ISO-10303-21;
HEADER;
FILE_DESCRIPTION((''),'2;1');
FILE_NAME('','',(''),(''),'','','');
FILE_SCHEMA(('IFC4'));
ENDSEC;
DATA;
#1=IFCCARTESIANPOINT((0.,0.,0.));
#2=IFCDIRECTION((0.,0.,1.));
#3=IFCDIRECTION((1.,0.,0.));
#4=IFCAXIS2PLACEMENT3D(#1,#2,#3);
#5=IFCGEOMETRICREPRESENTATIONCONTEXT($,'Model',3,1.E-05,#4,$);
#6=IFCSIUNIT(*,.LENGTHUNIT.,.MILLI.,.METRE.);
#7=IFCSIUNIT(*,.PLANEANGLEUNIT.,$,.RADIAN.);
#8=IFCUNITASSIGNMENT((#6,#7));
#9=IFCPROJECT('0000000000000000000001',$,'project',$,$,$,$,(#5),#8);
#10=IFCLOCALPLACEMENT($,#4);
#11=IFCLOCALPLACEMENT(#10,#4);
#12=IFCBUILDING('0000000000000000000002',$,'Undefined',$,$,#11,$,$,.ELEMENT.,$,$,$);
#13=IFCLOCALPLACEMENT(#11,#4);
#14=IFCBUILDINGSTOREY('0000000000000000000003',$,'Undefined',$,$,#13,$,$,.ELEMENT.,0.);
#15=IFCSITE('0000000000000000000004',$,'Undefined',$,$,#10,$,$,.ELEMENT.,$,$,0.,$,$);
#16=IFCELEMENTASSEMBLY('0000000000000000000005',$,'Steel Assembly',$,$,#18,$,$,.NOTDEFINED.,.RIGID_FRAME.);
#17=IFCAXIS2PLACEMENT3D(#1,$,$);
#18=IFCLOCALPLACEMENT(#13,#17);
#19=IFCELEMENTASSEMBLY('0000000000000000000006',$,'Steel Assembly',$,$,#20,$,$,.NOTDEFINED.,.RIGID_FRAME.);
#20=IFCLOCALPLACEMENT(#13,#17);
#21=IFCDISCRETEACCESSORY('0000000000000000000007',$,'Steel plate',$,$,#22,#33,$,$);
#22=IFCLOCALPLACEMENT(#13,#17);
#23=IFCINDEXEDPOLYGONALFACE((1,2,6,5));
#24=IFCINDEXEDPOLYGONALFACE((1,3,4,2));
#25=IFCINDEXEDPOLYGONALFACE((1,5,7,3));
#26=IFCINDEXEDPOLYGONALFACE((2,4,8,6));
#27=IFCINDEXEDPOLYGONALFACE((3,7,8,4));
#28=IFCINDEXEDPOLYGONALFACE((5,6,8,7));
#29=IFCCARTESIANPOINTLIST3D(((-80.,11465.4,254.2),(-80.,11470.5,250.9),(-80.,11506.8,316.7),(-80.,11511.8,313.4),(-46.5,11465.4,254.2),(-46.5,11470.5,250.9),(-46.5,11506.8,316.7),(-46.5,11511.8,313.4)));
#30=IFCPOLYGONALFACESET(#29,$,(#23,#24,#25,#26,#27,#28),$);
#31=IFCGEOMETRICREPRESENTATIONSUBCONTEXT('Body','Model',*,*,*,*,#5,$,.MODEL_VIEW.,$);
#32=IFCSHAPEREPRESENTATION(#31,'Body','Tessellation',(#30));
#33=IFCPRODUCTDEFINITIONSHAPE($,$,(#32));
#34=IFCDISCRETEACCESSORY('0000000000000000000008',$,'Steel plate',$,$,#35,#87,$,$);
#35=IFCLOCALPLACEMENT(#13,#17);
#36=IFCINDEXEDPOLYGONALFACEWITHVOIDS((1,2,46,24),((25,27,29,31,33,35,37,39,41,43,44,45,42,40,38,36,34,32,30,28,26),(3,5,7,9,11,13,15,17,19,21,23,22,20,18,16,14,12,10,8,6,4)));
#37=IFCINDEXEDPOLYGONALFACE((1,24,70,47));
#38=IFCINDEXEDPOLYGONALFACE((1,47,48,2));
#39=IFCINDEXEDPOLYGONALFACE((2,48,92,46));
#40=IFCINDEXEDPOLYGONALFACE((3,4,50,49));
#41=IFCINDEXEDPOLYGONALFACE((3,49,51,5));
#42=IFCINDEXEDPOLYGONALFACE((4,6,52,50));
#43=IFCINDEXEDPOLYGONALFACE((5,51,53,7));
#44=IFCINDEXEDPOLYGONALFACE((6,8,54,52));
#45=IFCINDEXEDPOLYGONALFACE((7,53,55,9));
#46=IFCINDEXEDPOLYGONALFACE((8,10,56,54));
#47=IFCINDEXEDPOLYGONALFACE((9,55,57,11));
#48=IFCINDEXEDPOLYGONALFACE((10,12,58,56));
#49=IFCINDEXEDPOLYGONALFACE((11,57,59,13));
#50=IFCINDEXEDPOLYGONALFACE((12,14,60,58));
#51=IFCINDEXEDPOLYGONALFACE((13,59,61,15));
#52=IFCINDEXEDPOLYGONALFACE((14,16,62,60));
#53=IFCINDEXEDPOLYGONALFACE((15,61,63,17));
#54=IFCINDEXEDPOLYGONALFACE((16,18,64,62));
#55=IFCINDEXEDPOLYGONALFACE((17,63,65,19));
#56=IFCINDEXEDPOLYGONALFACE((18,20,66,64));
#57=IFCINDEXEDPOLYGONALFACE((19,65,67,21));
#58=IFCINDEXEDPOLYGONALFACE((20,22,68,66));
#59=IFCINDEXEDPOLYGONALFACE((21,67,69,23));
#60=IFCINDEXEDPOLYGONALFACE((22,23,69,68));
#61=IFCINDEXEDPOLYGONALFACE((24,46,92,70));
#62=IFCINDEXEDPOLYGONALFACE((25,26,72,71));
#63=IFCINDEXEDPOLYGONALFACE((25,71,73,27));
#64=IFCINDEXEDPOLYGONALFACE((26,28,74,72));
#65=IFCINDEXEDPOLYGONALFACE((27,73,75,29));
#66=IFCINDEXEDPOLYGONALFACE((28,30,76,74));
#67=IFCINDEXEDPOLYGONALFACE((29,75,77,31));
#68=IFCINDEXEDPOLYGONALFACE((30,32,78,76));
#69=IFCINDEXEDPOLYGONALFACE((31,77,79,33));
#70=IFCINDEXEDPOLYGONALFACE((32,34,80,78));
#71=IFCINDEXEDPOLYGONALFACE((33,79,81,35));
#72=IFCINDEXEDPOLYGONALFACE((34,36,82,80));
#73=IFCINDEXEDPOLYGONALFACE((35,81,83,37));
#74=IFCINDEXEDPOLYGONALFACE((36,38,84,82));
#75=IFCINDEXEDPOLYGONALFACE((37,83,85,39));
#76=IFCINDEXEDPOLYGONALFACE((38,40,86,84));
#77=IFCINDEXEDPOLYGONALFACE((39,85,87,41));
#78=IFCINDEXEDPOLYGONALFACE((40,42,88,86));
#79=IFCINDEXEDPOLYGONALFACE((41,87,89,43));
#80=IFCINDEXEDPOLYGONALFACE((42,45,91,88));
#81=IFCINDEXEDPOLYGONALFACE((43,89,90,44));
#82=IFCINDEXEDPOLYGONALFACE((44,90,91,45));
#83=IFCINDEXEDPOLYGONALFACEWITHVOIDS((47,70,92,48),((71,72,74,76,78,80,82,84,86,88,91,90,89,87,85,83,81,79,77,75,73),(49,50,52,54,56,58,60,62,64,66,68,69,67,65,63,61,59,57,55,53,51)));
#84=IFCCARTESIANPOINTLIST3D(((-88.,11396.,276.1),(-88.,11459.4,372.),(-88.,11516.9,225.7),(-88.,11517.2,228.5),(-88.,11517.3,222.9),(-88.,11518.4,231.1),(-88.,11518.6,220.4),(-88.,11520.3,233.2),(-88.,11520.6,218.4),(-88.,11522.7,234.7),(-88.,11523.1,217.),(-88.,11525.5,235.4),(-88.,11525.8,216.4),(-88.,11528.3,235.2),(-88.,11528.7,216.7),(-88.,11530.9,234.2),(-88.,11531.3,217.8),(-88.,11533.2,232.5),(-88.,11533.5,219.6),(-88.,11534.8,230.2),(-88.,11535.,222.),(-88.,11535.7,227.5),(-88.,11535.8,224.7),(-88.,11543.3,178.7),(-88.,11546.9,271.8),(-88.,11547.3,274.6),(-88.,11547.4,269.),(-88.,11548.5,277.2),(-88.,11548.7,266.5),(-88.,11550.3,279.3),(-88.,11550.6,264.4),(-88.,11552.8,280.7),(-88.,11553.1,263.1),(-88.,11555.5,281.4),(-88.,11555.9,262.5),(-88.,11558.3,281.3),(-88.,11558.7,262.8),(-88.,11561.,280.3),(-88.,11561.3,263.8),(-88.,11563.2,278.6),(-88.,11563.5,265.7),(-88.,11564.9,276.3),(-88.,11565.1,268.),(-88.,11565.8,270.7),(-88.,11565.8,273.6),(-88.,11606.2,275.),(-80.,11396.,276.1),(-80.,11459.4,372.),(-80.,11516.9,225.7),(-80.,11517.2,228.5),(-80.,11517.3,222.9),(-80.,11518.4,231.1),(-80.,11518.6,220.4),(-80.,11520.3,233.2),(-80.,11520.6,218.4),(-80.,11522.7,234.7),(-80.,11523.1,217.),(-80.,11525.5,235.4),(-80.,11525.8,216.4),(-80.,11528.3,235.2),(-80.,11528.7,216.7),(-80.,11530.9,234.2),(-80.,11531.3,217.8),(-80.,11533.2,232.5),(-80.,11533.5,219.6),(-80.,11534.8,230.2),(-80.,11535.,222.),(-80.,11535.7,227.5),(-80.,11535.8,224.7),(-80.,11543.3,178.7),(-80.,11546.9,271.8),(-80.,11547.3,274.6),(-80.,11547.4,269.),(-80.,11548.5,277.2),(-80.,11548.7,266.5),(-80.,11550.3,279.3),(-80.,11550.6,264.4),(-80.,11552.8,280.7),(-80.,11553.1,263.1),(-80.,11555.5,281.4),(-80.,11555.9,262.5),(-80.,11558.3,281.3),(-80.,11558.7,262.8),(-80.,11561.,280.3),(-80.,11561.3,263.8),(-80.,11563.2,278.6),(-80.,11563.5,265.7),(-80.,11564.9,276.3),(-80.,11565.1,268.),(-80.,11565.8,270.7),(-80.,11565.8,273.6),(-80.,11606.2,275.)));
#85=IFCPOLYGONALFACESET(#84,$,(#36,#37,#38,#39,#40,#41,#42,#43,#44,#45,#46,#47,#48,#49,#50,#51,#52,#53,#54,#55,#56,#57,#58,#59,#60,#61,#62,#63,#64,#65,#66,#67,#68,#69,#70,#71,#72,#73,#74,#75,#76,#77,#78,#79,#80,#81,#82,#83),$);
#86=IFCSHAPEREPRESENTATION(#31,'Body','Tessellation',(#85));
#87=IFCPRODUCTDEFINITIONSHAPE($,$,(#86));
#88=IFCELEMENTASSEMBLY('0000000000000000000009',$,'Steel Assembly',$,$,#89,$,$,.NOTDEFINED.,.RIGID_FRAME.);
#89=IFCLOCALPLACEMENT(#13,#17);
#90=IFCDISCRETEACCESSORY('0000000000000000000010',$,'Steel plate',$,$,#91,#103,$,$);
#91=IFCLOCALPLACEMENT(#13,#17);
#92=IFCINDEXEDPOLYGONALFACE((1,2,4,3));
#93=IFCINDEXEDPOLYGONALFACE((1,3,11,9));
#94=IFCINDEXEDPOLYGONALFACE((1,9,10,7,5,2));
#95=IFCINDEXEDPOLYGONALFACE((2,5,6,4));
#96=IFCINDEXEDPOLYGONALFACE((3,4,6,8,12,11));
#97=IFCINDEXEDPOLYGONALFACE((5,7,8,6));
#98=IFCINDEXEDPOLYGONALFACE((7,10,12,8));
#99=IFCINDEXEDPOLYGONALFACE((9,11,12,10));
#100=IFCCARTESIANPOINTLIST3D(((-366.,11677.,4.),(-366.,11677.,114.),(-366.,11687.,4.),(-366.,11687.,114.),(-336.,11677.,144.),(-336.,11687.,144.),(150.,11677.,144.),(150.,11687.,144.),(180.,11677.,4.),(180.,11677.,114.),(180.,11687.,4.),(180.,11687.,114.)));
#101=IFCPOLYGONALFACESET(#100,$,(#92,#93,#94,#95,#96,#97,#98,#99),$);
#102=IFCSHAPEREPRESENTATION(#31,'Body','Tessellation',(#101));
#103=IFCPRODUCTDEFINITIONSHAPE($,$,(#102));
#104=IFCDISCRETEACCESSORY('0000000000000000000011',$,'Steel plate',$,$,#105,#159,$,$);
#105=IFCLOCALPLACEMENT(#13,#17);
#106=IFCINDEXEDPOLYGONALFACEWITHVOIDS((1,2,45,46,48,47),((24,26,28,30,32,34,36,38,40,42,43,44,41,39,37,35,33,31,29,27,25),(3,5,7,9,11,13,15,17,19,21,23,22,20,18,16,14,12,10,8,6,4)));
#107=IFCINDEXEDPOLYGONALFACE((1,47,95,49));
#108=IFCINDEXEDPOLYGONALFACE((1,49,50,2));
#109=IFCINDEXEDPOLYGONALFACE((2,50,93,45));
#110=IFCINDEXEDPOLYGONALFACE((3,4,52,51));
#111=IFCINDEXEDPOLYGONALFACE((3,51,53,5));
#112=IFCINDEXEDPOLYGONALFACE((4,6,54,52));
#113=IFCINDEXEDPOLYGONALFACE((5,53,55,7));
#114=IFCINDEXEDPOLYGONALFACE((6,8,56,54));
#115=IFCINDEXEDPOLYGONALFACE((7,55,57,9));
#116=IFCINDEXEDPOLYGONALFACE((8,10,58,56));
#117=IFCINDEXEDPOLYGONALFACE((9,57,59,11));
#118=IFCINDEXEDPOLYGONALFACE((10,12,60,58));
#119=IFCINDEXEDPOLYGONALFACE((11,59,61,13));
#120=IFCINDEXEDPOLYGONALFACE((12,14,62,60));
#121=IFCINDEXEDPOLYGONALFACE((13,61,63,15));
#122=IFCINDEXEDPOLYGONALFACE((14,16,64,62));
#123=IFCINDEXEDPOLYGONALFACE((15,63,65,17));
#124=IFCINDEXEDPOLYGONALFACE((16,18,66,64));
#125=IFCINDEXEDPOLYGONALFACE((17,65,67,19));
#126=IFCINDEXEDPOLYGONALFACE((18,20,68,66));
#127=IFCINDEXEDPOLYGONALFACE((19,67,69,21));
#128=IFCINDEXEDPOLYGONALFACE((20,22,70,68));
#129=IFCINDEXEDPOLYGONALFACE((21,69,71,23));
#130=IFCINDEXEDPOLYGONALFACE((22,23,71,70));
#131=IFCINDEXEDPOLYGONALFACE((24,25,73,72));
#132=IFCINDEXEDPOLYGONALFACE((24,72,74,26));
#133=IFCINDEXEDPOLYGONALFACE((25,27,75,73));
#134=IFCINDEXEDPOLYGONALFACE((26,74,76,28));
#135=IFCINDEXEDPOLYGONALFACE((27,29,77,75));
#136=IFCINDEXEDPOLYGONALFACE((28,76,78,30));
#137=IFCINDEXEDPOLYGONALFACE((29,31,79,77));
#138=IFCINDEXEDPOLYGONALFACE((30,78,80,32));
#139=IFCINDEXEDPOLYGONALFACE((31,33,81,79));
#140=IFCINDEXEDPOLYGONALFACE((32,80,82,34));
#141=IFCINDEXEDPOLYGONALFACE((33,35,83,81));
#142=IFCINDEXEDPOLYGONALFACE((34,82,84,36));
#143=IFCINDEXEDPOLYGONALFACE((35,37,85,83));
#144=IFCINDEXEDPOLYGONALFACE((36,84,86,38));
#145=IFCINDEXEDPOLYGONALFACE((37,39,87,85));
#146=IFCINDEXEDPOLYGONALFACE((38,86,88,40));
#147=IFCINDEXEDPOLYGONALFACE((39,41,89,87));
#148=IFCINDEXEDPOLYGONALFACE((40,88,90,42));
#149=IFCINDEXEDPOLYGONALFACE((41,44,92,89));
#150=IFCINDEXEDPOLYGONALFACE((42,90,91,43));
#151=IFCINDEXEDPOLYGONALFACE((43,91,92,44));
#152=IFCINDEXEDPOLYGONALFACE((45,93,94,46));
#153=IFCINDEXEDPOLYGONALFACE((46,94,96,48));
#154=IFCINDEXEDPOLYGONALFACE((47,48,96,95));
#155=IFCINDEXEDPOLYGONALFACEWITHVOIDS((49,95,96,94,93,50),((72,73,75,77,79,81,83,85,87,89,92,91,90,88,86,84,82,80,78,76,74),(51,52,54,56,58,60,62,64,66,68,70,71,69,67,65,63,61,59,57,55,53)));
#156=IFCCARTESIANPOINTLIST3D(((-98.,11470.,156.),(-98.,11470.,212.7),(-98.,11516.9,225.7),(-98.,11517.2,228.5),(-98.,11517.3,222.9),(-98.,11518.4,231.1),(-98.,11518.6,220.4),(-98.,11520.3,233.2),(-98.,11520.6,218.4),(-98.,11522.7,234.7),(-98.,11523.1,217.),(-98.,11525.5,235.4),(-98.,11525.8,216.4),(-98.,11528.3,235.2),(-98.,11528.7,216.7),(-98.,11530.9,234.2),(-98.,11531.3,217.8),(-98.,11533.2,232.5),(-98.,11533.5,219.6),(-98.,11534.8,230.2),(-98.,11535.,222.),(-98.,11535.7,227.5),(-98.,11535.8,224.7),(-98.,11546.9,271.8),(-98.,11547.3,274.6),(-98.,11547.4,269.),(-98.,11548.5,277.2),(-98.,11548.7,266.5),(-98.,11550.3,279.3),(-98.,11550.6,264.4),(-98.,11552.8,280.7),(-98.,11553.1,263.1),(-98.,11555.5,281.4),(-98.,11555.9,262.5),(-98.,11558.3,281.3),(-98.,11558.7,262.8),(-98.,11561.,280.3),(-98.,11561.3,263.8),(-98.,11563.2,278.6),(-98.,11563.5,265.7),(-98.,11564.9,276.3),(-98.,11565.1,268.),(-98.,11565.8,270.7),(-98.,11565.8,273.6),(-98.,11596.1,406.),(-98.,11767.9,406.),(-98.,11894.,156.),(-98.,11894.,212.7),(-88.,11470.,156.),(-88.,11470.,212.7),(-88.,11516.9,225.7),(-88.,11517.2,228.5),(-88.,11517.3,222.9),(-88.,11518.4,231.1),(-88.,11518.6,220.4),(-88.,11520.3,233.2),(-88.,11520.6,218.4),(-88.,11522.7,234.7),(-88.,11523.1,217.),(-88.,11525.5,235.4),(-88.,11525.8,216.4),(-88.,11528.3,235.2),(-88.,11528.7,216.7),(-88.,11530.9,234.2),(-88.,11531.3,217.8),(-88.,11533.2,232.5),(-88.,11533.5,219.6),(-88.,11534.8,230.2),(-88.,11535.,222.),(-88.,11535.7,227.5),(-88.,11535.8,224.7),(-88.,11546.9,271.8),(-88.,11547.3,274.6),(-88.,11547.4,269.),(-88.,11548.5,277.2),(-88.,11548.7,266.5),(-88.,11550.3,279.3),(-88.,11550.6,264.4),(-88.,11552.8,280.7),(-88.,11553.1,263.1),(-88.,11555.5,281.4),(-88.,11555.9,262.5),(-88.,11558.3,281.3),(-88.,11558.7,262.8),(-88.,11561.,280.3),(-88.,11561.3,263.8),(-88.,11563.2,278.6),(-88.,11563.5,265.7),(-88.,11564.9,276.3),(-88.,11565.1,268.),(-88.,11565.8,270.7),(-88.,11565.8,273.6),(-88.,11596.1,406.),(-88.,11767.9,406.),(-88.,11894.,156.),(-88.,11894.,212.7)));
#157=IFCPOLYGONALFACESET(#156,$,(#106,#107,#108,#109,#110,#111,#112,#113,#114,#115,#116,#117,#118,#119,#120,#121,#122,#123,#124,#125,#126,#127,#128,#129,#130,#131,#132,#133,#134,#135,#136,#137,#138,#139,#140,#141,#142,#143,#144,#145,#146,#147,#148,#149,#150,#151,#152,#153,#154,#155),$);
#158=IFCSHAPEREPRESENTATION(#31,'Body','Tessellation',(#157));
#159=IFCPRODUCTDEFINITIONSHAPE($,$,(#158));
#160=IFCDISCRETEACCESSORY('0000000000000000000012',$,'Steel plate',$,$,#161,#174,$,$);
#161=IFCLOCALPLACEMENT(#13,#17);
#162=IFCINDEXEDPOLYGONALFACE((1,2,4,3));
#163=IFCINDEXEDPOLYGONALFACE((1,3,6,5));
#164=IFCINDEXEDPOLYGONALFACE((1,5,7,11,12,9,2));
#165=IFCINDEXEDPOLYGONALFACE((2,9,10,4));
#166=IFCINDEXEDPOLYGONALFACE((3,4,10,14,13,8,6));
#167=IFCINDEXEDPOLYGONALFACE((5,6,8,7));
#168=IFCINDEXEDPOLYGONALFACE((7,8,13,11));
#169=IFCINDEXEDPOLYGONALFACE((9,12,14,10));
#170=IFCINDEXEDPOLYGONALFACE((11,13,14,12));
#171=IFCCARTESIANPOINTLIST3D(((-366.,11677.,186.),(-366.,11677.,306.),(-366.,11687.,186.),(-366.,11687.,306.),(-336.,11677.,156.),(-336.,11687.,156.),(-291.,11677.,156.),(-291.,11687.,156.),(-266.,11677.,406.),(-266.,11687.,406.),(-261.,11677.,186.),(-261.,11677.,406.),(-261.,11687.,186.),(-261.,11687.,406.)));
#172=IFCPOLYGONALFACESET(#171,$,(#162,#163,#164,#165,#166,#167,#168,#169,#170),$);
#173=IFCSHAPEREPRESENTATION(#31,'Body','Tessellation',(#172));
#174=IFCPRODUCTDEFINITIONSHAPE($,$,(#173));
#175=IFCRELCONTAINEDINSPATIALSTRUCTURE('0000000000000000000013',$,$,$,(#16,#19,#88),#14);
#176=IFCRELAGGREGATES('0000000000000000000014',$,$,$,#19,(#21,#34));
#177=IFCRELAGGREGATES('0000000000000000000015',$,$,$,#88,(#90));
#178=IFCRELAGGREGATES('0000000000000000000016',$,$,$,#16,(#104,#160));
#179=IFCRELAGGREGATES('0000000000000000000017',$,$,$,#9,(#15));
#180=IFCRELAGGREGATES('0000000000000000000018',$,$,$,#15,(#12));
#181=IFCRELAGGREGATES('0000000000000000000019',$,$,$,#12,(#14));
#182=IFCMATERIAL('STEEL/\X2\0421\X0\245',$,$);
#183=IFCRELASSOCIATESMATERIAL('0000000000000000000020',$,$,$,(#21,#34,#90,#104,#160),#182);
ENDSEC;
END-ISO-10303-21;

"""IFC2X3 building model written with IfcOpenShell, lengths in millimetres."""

from ifc_helpers import new_model, si_unit, frame, origin_with_axes, origin_2d_with_axis, place, context, subcontext, project, spatial, polyline, circle, outline, extrude, source, transform, mapped, material, element, aggregate, save


model = new_model("IFC2X3")

# Units and contexts
model_context = context("Model", 3, precision=1e-05, world=origin_with_axes())
body_context = subcontext(model_context, "Body", "Model", "MODEL_VIEW")
ifc_project = project(units=[si_unit("LENGTHUNIT", "METRE", prefix="MILLI"), si_unit("PLANEANGLEUNIT", "RADIAN")], contexts=[model_context])

# Site, building, storey
site_placement = place(None, origin_with_axes())
site = spatial("IfcSite", under=ifc_project, at=site_placement, Name="Undefined", CompositionType="ELEMENT", RefElevation=0.0)
building_placement = place(site_placement, origin_with_axes())
building = spatial("IfcBuilding", under=site, at=building_placement, Name="Undefined", CompositionType="ELEMENT")
storey_placement = place(building_placement, origin_with_axes())
storey = spatial("IfcBuildingStorey", under=building, at=storey_placement, Name="Undefined", CompositionType="ELEMENT", Elevation=0.0)

# Element assembly
assembly_1_placement = place(storey_placement, origin_with_axes())
assembly_1 = element("IfcElementAssembly", 1, at=assembly_1_placement, inside=storey, Name="Steel Assembly", AssemblyPlace="NOTDEFINED", PredefinedType="RIGID_FRAME")
ifc_material_1 = material(Name="STEEL/С245")

# Element assembly
assembly_2_placement = place(storey_placement, origin_with_axes())
assembly_2 = element("IfcElementAssembly", 2, at=assembly_2_placement, inside=storey, Name="Steel Assembly", AssemblyPlace="NOTDEFINED", PredefinedType="RIGID_FRAME")

# Discrete accessories, openings
discrete_accessory_1_placement = place(assembly_2_placement, frame((-46.5, 11467.9, 252.5), z_axis=(0.0, -0.83425, 0.551387), x_axis=(0.0, 0.551387, 0.83425)))
discrete_accessory_1 = element("IfcDiscreteAccessory", 3, at=discrete_accessory_1_placement, material=ifc_material_1, Name="Steel plate", context=body_context, shape_type="SweptSolid", body=[
    extrude(outline(polyline([(0.0, 0.0), (75.0, 0.0), (75.0, 75.0), (0.0, 75.0), (0.0, 0.0)])), frame((0.0, 0.0, -3.0), z_axis=(0.0, 0.0, 1.0), x_axis=(1.0, 0.0, 0.0)), (0.0, 0.0, 1.0), 6.0),
])
opening_1_placement = place(assembly_2_placement, frame((-46.5, 11467.9, 252.5), z_axis=(0.0, -0.83425, 0.551387), x_axis=(0.0, 0.551387, 0.83425)))
element("IfcOpeningElement", 4, at=opening_1_placement, cuts=discrete_accessory_1, ObjectType="Recess", context=body_context, shape_type="SweptSolid", body=[
    extrude(outline(polyline([(0.0, 0.0), (75.0, 0.0), (75.0, 150.0), (0.0, 150.0), (0.0, 0.0)])), frame((-37.5, 108.5, -6.0), z_axis=(0.0, 0.0, 1.0), x_axis=(0.0, -1.0, 0.0)), (0.0, 0.0, 1.0), 12.0),
])
discrete_accessory_2_placement = place(assembly_2_placement, frame((-84.0, 11606.2, 275.0), z_axis=(-1.0, 0.0, 0.0), x_axis=(0.0, -0.546313, -0.837581)))
discrete_accessory_2 = element("IfcDiscreteAccessory", 5, at=discrete_accessory_2_placement, material=ifc_material_1, Name="Steel plate", context=body_context, shape_type="SweptSolid", body=[
    extrude(outline(polyline([(0.0, 0.0), (115.0, 0.0), (113.9, 176.6), (-1.1, 175.9), (0.0, 0.0)])), frame((0.0, 0.0, -4.0), z_axis=(0.0, 0.0, 1.0), x_axis=(1.0, 0.0, 0.0)), (0.0, 0.0, 1.0), 8.0),
])
shared_shape_1 = source(origin_with_axes(), body_context, "Body", "SweptSolid", [
    extrude(circle(Radius=9.5, at=origin_2d_with_axis()), frame((0.0, -4.1, 0.0), z_axis=(0.0, 1.0, 0.0), x_axis=(1.0, 0.0, 0.0)), (0.0, 0.0, 1.0), 12.3),
])
opening_2_placement = place(assembly_2_placement, frame((-84.0, 11541.4, 248.9), z_axis=(0.0, 0.546313, 0.837581), x_axis=(0.0, -0.837581, 0.546313)))
element("IfcOpeningElement", 6, at=opening_2_placement, cuts=discrete_accessory_2, ObjectType="Opening", context=body_context, shape_type="MappedRepresentation", body=[
    mapped(shared_shape_1, transform((0.0, 0.0, -27.5))),
    mapped(shared_shape_1, transform((0.0, 0.0, 27.5))),
])
aggregate(assembly_2, [discrete_accessory_1, discrete_accessory_2])

# Element assembly, discrete accessory
assembly_3_placement = place(storey_placement, origin_with_axes())
assembly_3 = element("IfcElementAssembly", 7, at=assembly_3_placement, inside=storey, Name="Steel Assembly", AssemblyPlace="NOTDEFINED", PredefinedType="RIGID_FRAME")
discrete_accessory_3_placement = place(assembly_3_placement, frame((-366.0, 11682.0, 4.0), z_axis=(0.0, 1.0, 0.0), x_axis=(0.0, 0.0, 1.0)))
discrete_accessory_3 = element("IfcDiscreteAccessory", 8, at=discrete_accessory_3_placement, material=ifc_material_1, Name="Steel plate", context=body_context, shape_type="SweptSolid", body=[
    extrude(outline(polyline([(0.0, 0.0), (110.0, 0.0), (140.0, 30.0), (140.0, 516.0), (110.0, 546.0), (0.0, 546.0), (0.0, 0.0)])), frame((0.0, 0.0, -5.0), z_axis=(0.0, 0.0, 1.0), x_axis=(1.0, 0.0, 0.0)), (0.0, 0.0, 1.0), 10.0),
])
aggregate(assembly_3, [discrete_accessory_3])

# Discrete accessory, opening
discrete_accessory_4_placement = place(assembly_1_placement, frame((-93.0, 11470.0, 156.0), z_axis=(1.0, 0.0, 0.0), x_axis=(0.0, 1.0, 0.0)))
discrete_accessory_4 = element("IfcDiscreteAccessory", 9, at=discrete_accessory_4_placement, material=ifc_material_1, Name="Steel plate", context=body_context, shape_type="SweptSolid", body=[
    extrude(outline(polyline([(0.0, 0.0), (424.0, 0.0), (424.0, 56.7), (297.9, 250.0), (126.1, 250.0), (0.0, 56.7), (0.0, 0.0)])), frame((0.0, 0.0, -5.0), z_axis=(0.0, 0.0, 1.0), x_axis=(1.0, 0.0, 0.0)), (0.0, 0.0, 1.0), 10.0),
])
shared_shape_2 = source(origin_with_axes(), body_context, "Body", "SweptSolid", [
    extrude(circle(Radius=9.5, at=origin_2d_with_axis()), frame((0.0, -14.1, 0.0), z_axis=(0.0, 1.0, 0.0), x_axis=(1.0, 0.0, 0.0)), (0.0, 0.0, 1.0), 24.3),
])
opening_3_placement = place(assembly_1_placement, frame((-84.0, 11541.4, 248.9), z_axis=(0.0, 0.546313, 0.837581), x_axis=(0.0, -0.837581, 0.546313)))
element("IfcOpeningElement", 10, at=opening_3_placement, cuts=discrete_accessory_4, ObjectType="Opening", context=body_context, shape_type="MappedRepresentation", body=[
    mapped(shared_shape_2, transform((0.0, 0.0, -27.5))),
    mapped(shared_shape_2, transform((0.0, 0.0, 27.5))),
])

# Discrete accessory
discrete_accessory_5_placement = place(assembly_1_placement, frame((-261.0, 11682.0, 156.0), z_axis=(0.0, 1.0, 0.0), x_axis=(-1.0, 0.0, 0.0)))
discrete_accessory_5 = element("IfcDiscreteAccessory", 11, at=discrete_accessory_5_placement, material=ifc_material_1, Name="Steel plate", context=body_context, shape_type="SweptSolid", body=[
    extrude(outline(polyline([(0.0, 30.0), (30.0, 0.0), (75.0, 0.0), (105.0, 30.0), (105.0, 150.0), (5.0, 250.0), (0.0, 250.0), (0.0, 30.0)])), frame((0.0, 0.0, -5.0), z_axis=(0.0, 0.0, 1.0), x_axis=(1.0, 0.0, 0.0)), (0.0, 0.0, 1.0), 10.0),
])
aggregate(assembly_1, [discrete_accessory_4, discrete_accessory_5])

save(model, "model.ifc")
